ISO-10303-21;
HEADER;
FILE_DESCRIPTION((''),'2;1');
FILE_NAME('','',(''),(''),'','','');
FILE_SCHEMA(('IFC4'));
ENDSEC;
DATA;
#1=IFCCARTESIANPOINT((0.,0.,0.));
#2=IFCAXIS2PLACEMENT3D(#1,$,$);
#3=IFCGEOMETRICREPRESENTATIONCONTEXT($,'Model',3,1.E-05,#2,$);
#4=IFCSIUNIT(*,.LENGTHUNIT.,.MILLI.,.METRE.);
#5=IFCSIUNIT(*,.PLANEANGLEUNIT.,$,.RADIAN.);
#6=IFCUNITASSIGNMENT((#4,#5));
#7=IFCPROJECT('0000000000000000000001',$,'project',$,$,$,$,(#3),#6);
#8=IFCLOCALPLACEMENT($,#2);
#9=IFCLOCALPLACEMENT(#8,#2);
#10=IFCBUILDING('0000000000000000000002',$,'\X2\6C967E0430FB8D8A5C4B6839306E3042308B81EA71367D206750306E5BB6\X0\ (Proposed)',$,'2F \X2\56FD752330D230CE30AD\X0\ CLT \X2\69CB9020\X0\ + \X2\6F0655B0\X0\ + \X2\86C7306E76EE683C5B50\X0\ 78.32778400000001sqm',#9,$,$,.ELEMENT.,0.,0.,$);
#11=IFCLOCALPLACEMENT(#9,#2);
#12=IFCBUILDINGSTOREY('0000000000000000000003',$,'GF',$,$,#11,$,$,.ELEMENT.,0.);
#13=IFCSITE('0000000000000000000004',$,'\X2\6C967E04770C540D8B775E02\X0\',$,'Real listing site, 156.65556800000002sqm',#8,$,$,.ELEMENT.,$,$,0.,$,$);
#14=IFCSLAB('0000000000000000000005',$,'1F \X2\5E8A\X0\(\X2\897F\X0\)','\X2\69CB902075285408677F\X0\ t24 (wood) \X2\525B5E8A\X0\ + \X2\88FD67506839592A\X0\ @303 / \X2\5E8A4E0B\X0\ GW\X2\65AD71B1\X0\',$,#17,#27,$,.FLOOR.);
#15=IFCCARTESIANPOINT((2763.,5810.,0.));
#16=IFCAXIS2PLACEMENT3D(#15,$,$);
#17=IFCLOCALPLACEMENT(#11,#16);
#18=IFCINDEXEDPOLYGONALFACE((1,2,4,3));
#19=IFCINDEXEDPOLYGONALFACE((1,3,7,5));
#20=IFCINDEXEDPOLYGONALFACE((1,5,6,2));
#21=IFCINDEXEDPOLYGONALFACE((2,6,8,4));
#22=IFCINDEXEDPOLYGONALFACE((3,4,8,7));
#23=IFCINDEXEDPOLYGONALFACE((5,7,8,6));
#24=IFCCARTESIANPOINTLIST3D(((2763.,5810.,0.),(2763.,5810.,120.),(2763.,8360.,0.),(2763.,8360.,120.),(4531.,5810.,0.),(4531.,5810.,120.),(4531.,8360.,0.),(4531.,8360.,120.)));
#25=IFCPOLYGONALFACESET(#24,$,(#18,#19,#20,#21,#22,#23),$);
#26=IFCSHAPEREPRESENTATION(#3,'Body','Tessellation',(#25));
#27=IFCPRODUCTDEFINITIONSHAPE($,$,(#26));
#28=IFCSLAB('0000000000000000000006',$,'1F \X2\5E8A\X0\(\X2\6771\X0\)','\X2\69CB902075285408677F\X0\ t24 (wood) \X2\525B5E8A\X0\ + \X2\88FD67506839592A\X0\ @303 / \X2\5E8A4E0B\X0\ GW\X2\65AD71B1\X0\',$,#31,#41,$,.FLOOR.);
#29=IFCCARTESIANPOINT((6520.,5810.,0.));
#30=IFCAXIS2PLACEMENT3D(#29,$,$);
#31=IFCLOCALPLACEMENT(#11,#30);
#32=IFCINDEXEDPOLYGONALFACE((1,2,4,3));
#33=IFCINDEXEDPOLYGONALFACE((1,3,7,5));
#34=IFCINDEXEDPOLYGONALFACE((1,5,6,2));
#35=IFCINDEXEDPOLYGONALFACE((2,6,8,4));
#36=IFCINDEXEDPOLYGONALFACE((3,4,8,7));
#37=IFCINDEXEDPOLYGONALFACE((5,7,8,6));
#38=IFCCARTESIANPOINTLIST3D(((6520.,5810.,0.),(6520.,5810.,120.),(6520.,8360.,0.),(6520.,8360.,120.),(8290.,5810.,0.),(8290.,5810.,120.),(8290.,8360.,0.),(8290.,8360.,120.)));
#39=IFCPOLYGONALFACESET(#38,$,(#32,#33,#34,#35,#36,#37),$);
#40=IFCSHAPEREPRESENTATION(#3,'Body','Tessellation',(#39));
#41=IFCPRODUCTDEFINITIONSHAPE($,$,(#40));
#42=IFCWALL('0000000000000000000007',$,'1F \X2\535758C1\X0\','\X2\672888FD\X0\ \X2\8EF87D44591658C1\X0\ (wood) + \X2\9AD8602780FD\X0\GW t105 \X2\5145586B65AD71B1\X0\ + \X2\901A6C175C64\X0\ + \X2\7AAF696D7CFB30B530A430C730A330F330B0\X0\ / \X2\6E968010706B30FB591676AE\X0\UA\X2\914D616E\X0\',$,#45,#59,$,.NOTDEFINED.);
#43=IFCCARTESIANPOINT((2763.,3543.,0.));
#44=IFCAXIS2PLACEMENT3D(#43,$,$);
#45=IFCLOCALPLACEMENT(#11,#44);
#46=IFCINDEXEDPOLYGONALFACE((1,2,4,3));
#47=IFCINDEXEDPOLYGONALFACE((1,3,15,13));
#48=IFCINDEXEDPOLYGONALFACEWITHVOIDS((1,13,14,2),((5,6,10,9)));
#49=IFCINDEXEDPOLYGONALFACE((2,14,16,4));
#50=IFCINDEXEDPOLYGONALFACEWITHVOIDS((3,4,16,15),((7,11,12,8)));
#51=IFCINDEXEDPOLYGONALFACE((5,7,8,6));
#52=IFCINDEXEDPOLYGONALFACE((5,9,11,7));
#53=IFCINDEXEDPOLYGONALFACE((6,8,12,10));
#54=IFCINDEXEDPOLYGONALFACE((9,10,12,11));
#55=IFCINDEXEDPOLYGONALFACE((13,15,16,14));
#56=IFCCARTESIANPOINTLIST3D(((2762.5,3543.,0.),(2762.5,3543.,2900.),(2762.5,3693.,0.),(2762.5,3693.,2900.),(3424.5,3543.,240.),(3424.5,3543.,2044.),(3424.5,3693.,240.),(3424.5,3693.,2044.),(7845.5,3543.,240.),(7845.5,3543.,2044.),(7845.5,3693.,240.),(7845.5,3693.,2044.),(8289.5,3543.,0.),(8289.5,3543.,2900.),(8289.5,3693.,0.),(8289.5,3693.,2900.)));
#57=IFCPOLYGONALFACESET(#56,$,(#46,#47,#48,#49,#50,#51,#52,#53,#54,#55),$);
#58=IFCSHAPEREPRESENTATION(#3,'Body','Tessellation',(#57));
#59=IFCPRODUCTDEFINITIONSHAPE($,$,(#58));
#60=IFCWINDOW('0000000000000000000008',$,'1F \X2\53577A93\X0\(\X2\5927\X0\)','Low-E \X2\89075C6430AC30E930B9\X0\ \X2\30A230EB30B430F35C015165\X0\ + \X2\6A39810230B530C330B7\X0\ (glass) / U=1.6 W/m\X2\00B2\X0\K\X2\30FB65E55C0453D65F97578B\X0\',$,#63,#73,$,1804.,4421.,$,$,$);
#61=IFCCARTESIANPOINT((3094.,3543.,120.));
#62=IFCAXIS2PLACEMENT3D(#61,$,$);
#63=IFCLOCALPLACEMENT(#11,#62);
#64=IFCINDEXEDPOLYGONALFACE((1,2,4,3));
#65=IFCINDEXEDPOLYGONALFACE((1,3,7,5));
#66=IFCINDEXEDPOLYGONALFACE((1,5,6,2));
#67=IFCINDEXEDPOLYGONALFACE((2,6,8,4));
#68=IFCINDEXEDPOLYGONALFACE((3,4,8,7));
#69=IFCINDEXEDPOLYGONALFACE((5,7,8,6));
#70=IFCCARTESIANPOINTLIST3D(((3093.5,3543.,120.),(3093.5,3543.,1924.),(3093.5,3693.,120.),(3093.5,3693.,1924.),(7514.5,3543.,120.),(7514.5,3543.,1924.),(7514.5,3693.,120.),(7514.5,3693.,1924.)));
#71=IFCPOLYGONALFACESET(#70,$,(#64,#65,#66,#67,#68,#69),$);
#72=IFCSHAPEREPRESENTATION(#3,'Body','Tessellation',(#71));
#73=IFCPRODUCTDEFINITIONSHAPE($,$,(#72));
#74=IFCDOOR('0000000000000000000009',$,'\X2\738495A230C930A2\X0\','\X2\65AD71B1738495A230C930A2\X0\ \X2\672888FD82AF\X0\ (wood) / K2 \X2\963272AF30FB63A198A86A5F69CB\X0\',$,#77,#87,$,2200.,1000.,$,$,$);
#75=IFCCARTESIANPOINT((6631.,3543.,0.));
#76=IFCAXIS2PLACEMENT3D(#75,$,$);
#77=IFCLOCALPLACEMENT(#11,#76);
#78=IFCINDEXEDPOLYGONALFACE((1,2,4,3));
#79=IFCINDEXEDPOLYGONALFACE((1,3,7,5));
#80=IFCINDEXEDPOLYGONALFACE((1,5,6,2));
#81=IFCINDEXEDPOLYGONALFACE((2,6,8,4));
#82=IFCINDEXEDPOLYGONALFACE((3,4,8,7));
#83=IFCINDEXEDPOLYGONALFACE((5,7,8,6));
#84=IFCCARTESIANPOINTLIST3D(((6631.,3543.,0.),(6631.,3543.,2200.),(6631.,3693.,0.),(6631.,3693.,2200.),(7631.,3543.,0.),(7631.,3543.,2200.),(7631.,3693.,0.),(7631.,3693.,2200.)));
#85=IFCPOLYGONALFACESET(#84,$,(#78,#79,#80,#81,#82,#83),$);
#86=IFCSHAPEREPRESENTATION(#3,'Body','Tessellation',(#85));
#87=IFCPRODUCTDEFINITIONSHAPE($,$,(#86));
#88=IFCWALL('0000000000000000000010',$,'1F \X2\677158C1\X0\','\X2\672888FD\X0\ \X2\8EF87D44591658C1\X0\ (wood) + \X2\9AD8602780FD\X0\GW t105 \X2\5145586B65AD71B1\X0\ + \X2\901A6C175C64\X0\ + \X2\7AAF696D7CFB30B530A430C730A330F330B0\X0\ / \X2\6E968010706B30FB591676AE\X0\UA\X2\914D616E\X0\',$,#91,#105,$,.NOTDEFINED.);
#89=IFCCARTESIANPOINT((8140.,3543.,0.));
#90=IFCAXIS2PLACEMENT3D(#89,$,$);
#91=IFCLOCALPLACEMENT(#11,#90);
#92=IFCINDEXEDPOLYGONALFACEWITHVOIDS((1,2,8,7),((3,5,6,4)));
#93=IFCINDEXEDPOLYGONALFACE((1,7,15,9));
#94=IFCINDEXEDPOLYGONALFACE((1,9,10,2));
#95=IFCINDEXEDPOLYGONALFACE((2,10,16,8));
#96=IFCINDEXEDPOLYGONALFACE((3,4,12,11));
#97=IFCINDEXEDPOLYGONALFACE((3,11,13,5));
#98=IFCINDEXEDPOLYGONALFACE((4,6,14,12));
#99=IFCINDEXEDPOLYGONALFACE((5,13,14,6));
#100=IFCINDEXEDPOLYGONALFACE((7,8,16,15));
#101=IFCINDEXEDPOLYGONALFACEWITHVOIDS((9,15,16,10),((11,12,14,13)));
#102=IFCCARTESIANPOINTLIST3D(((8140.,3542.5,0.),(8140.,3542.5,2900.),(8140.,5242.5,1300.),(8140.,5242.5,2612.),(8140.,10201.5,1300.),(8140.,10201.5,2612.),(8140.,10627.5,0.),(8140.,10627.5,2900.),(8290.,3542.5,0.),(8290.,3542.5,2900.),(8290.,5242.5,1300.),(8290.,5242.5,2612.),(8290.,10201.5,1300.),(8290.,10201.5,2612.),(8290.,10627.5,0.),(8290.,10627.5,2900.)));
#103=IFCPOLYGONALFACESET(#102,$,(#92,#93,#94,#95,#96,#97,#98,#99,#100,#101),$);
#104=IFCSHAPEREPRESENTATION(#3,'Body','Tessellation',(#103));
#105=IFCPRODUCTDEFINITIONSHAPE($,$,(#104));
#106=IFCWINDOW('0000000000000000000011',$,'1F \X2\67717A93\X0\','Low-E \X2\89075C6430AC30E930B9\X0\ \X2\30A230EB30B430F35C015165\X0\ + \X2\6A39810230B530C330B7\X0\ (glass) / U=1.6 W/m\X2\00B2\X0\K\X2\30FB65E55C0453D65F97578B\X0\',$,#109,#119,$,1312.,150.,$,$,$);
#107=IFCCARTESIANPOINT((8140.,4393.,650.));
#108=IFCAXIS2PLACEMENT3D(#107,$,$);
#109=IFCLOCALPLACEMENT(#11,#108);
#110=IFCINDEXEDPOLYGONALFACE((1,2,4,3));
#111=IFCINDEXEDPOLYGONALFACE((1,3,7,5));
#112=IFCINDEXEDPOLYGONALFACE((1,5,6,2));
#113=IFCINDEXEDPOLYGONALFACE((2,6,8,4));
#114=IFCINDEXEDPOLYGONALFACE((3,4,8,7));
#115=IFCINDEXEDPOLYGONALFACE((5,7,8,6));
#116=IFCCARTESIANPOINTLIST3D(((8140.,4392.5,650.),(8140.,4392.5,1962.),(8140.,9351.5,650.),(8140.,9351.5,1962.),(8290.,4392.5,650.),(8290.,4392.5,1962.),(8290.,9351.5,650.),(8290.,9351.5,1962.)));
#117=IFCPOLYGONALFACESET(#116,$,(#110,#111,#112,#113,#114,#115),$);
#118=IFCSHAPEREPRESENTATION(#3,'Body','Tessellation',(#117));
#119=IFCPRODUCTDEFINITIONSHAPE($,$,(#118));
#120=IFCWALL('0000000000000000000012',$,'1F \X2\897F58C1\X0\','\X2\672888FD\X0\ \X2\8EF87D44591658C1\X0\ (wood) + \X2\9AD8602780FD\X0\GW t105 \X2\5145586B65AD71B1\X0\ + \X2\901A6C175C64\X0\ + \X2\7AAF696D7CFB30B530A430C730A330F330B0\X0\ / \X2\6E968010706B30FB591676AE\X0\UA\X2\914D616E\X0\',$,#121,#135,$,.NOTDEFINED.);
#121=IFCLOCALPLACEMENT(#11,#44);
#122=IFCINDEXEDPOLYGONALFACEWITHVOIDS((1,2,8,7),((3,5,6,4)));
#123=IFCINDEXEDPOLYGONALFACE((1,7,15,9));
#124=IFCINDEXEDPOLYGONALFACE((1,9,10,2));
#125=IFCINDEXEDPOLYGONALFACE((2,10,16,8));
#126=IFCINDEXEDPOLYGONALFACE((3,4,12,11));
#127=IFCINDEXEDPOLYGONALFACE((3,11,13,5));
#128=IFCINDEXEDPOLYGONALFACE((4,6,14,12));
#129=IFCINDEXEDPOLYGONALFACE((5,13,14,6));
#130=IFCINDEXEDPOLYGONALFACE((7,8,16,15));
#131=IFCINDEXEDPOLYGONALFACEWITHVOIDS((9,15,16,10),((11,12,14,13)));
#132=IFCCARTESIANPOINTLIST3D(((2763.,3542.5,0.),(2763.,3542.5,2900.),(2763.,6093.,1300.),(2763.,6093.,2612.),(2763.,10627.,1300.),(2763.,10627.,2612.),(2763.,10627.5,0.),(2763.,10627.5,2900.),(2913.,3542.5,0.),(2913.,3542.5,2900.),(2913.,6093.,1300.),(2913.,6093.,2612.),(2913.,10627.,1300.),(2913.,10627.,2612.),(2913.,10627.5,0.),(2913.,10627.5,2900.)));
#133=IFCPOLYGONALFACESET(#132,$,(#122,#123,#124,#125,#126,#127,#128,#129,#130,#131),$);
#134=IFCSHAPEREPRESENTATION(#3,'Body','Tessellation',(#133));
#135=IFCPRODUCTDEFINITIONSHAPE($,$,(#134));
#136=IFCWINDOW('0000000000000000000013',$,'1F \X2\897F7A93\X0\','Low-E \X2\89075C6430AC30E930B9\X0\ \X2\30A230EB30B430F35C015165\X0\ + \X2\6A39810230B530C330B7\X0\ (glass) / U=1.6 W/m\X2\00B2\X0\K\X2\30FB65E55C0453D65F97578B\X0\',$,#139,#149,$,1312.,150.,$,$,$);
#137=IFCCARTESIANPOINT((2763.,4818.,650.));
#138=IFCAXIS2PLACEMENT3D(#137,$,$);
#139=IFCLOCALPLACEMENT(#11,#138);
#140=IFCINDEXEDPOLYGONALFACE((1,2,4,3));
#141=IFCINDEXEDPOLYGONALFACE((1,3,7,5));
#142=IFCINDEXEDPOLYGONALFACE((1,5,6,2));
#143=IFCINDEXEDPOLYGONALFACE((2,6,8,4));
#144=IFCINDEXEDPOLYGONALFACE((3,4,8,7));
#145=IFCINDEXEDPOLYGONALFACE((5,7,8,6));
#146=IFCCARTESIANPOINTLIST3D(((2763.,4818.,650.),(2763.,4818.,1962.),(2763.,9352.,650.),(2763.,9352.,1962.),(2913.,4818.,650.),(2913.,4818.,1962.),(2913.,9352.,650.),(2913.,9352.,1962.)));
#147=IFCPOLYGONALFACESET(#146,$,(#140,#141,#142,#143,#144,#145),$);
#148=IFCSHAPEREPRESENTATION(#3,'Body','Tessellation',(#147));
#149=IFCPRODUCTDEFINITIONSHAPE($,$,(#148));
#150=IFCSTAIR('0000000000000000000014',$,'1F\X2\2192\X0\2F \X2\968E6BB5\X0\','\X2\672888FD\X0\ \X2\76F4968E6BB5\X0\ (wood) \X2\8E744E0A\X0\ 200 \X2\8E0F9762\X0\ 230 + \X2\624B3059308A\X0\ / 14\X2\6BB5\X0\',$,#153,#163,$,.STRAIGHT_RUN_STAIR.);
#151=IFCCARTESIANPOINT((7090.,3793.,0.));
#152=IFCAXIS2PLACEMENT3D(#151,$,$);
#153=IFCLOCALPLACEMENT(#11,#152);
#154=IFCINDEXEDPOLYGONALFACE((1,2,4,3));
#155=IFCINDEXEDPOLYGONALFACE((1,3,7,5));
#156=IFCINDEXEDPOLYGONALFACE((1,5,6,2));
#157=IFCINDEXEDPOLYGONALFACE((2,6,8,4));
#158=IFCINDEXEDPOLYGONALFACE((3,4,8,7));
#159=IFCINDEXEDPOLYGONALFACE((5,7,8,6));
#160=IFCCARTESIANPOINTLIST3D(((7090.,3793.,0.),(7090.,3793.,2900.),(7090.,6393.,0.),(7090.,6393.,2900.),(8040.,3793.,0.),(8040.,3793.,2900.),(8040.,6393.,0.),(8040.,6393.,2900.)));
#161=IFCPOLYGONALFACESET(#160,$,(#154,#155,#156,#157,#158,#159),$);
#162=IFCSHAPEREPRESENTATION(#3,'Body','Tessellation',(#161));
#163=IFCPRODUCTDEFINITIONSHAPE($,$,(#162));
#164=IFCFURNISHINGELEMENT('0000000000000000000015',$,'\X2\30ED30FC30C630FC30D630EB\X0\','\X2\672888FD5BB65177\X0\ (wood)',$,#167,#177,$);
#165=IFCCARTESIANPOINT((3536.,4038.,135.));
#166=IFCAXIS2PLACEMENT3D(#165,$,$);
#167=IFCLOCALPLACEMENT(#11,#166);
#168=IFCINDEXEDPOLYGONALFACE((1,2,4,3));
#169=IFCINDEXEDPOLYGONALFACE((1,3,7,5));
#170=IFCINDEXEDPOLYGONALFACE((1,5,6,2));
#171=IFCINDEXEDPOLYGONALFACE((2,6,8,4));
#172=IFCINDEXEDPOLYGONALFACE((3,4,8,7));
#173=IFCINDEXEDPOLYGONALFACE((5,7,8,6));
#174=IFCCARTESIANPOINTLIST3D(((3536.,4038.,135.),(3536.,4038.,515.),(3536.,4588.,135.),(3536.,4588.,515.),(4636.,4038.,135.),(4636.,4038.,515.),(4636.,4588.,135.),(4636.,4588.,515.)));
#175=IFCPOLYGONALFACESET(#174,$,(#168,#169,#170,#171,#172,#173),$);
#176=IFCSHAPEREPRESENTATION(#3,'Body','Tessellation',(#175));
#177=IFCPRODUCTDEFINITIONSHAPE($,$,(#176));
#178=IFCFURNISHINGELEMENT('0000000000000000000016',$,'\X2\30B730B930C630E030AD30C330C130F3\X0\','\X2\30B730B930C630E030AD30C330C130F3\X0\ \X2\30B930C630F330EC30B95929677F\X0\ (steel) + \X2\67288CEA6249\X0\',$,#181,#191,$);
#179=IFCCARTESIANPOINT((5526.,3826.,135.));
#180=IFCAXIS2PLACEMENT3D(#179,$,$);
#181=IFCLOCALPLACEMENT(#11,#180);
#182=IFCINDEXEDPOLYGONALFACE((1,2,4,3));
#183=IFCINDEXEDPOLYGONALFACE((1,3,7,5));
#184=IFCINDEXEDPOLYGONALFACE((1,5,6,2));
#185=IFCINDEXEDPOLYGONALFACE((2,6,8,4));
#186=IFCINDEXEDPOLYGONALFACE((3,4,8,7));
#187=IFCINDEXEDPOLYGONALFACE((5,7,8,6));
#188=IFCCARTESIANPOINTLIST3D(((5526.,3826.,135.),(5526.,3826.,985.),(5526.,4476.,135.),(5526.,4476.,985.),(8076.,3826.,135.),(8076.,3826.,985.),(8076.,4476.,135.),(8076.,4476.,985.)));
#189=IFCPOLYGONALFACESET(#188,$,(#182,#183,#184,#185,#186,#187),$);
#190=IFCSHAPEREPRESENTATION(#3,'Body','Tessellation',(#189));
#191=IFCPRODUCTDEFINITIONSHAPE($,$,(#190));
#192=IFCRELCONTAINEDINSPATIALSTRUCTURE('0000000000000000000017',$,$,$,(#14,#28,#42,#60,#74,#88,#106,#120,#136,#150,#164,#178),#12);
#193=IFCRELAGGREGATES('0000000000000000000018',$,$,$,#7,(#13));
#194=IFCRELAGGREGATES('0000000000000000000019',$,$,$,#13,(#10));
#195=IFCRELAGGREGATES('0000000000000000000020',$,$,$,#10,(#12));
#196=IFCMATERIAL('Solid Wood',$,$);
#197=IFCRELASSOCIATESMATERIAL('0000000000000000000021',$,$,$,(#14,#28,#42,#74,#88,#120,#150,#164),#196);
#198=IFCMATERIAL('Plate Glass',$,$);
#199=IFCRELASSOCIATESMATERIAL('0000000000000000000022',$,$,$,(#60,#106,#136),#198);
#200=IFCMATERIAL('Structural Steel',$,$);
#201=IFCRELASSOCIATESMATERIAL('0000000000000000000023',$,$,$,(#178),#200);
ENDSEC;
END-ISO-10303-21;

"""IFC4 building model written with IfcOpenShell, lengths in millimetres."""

from ifc_helpers import new_model, si_unit, frame, frame_2d, origin, place, context, project, spatial, rectangle, extrude, material, element, fill, save


model = new_model("IFC4")

# Units and contexts
model_context = context("Model", 3, precision=1e-05, world=origin())
ifc_project = project(units=[si_unit("LENGTHUNIT", "METRE", prefix="MILLI"), si_unit("PLANEANGLEUNIT", "RADIAN")], contexts=[model_context])

# Site, building, storey
site_placement = place(None, origin())
site = spatial("IfcSite", under=ifc_project, at=site_placement, Name="沖縄県名護市", ObjectType="Real listing site, 156.65556800000002sqm", CompositionType="ELEMENT", RefElevation=0.0)
building_placement = place(site_placement, origin())
building = spatial("IfcBuilding", under=site, at=building_placement, Name="沖縄・越屋根のある自然素材の家 (Proposed)", ObjectType="2F 国産ヒノキ CLT 構造 + 漆喰 + 蛇の目格子 78.32778400000001sqm", CompositionType="ELEMENT", ElevationOfRefHeight=0.0, ElevationOfTerrain=0.0)
storey_placement = place(building_placement, origin())
storey = spatial("IfcBuildingStorey", under=building, at=storey_placement, Name="GF", CompositionType="ELEMENT", Elevation=0.0)

# Slabs
ifc_material_1 = material(Name="Solid Wood")
slab_1_placement = place(storey_placement, frame((2763.0, 5810.0, 0.0)))
element("IfcSlab", 1, at=slab_1_placement, inside=storey, material=ifc_material_1, Name="1F 床(西)", Description="構造用合板 t24 (wood) 剛床 + 製材根太 @303 / 床下 GW断熱", PredefinedType="FLOOR", context=model_context, shape_type="SweptSolid", body=[
    extrude(rectangle(XDim=1768.0, YDim=2550.0, at=frame_2d((884.0, 1275.0))), frame((2763.0, 5810.0, 0.0)), (0.0, 0.0, 1.0), 120.0),
])
slab_2_placement = place(storey_placement, frame((6520.0, 5810.0, 0.0)))
element("IfcSlab", 2, at=slab_2_placement, inside=storey, material=ifc_material_1, Name="1F 床(東)", Description="構造用合板 t24 (wood) 剛床 + 製材根太 @303 / 床下 GW断熱", PredefinedType="FLOOR", context=model_context, shape_type="SweptSolid", body=[
    extrude(rectangle(XDim=1770.0, YDim=2550.0, at=frame_2d((885.0, 1275.0))), frame((6520.0, 5810.0, 0.0)), (0.0, 0.0, 1.0), 120.0),
])

# Wall, openings, window, door
wall_1_placement = place(storey_placement, frame((2763.0, 3543.0, 0.0)))
wall_1 = element("IfcWall", 3, at=wall_1_placement, inside=storey, material=ifc_material_1, Name="1F 南壁", Description="木製 軸組外壁 (wood) + 高性能GW t105 充填断熱 + 通気層 + 窯業系サイディング / 準耐火・外皮UA配慮", PredefinedType="NOTDEFINED", context=model_context, shape_type="SweptSolid", body=[
    extrude(rectangle(XDim=5527.0, YDim=150.0, at=frame_2d((2763.0, 75.0))), frame((2763.0, 3543.0, 0.0)), (0.0, 0.0, 1.0), 2900.0),
])
opening_1_placement = place(storey_placement, frame((3094.0, 3543.0, 120.0)))
opening_1 = element("IfcOpeningElement", 4, at=opening_1_placement, cuts=wall_1, PredefinedType="NOTDEFINED", context=model_context, shape_type="SweptSolid", body=[
    extrude(rectangle(XDim=4421.0, YDim=150.0, at=frame_2d((2210.0, 75.0))), frame((3094.0, 3543.0, 120.0)), (0.0, 0.0, 1.0), 1804.0),
])
opening_2_placement = place(storey_placement, frame((6631.0, 3543.0, 0.0)))
opening_2 = element("IfcOpeningElement", 5, at=opening_2_placement, cuts=wall_1, PredefinedType="NOTDEFINED", context=model_context, shape_type="SweptSolid", body=[
    extrude(rectangle(XDim=1000.0, YDim=150.0, at=frame_2d((500.0, 75.0))), frame((6631.0, 3543.0, 0.0)), (0.0, 0.0, 1.0), 2200.0),
])
ifc_material_2 = material(Name="Plate Glass")
window_1_placement = place(storey_placement, frame((3094.0, 3543.0, 120.0)))
window_1 = element("IfcWindow", 6, at=window_1_placement, inside=storey, material=ifc_material_2, Name="1F 南窓(大)", Description="Low-E 複層ガラス アルゴン封入 + 樹脂サッシ (glass) / U=1.6 W/m²K・日射取得型", OverallHeight=1804.0, OverallWidth=4421.0, context=model_context, shape_type="SweptSolid", body=[
    extrude(rectangle(XDim=4421.0, YDim=150.0, at=frame_2d((2210.0, 75.0))), frame((3094.0, 3543.0, 120.0)), (0.0, 0.0, 1.0), 1804.0),
])
fill(opening_1, window_1)
door_placement = place(storey_placement, frame((6631.0, 3543.0, 0.0)))
door = element("IfcDoor", 7, at=door_placement, inside=storey, material=ifc_material_1, Name="玄関ドア", Description="断熱玄関ドア 木製芯 (wood) / K2 防犯・採風機構", OverallHeight=2200.0, OverallWidth=1000.0, context=model_context, shape_type="SweptSolid", body=[
    extrude(rectangle(XDim=1000.0, YDim=150.0, at=frame_2d((500.0, 75.0))), frame((6631.0, 3543.0, 0.0)), (0.0, 0.0, 1.0), 2200.0),
])
fill(opening_2, door)

# Walls, openings, windows
wall_2_placement = place(storey_placement, frame((8140.0, 3543.0, 0.0)))
wall_2 = element("IfcWall", 8, at=wall_2_placement, inside=storey, material=ifc_material_1, Name="1F 東壁", Description="木製 軸組外壁 (wood) + 高性能GW t105 充填断熱 + 通気層 + 窯業系サイディング / 準耐火・外皮UA配慮", PredefinedType="NOTDEFINED", context=model_context, shape_type="SweptSolid", body=[
    extrude(rectangle(XDim=150.0, YDim=7085.0, at=frame_2d((75.0, 3542.0))), frame((8140.0, 3543.0, 0.0)), (0.0, 0.0, 1.0), 2900.0),
])
opening_3_placement = place(storey_placement, frame((8140.0, 4393.0, 650.0)))
opening_3 = element("IfcOpeningElement", 9, at=opening_3_placement, cuts=wall_2, PredefinedType="NOTDEFINED", context=model_context, shape_type="SweptSolid", body=[
    extrude(rectangle(XDim=150.0, YDim=4959.0, at=frame_2d((75.0, 2479.0))), frame((8140.0, 4393.0, 650.0)), (0.0, 0.0, 1.0), 1312.0),
])
window_2_placement = place(storey_placement, frame((8140.0, 4393.0, 650.0)))
window_2 = element("IfcWindow", 10, at=window_2_placement, inside=storey, material=ifc_material_2, Name="1F 東窓", Description="Low-E 複層ガラス アルゴン封入 + 樹脂サッシ (glass) / U=1.6 W/m²K・日射取得型", OverallHeight=1312.0, OverallWidth=150.0, context=model_context, shape_type="SweptSolid", body=[
    extrude(rectangle(XDim=150.0, YDim=4959.0, at=frame_2d((75.0, 2479.0))), frame((8140.0, 4393.0, 650.0)), (0.0, 0.0, 1.0), 1312.0),
])
fill(opening_3, window_2)
wall_3_placement = place(storey_placement, frame((2763.0, 3543.0, 0.0)))
wall_3 = element("IfcWall", 11, at=wall_3_placement, inside=storey, material=ifc_material_1, Name="1F 西壁", Description="木製 軸組外壁 (wood) + 高性能GW t105 充填断熱 + 通気層 + 窯業系サイディング / 準耐火・外皮UA配慮", PredefinedType="NOTDEFINED", context=model_context, shape_type="SweptSolid", body=[
    extrude(rectangle(XDim=150.0, YDim=7085.0, at=frame_2d((75.0, 3542.0))), frame((2763.0, 3543.0, 0.0)), (0.0, 0.0, 1.0), 2900.0),
])
opening_4_placement = place(storey_placement, frame((2763.0, 4818.0, 650.0)))
opening_4 = element("IfcOpeningElement", 12, at=opening_4_placement, cuts=wall_3, PredefinedType="NOTDEFINED", context=model_context, shape_type="SweptSolid", body=[
    extrude(rectangle(XDim=150.0, YDim=4534.0, at=frame_2d((75.0, 2267.0))), frame((2763.0, 4818.0, 650.0)), (0.0, 0.0, 1.0), 1312.0),
])
window_3_placement = place(storey_placement, frame((2763.0, 4818.0, 650.0)))
window_3 = element("IfcWindow", 13, at=window_3_placement, inside=storey, material=ifc_material_2, Name="1F 西窓", Description="Low-E 複層ガラス アルゴン封入 + 樹脂サッシ (glass) / U=1.6 W/m²K・日射取得型", OverallHeight=1312.0, OverallWidth=150.0, context=model_context, shape_type="SweptSolid", body=[
    extrude(rectangle(XDim=150.0, YDim=4534.0, at=frame_2d((75.0, 2267.0))), frame((2763.0, 4818.0, 650.0)), (0.0, 0.0, 1.0), 1312.0),
])
fill(opening_4, window_3)

# Stair
stair_placement = place(storey_placement, frame((7090.0, 3793.0, 0.0)))
element("IfcStair", 14, at=stair_placement, inside=storey, material=ifc_material_1, Name="1F→2F 階段", Description="木製 直階段 (wood) 蹴上 200 踏面 230 + 手すり / 14段", PredefinedType="STRAIGHT_RUN_STAIR", context=model_context, shape_type="SweptSolid", body=[
    extrude(rectangle(XDim=950.0, YDim=2600.0, at=frame_2d((475.0, 1300.0))), frame((7090.0, 3793.0, 0.0)), (0.0, 0.0, 1.0), 2900.0),
])

# Furnishing elements
furnishing_1_placement = place(storey_placement, frame((3536.0, 4038.0, 135.0)))
element("IfcFurnishingElement", 15, at=furnishing_1_placement, inside=storey, material=ifc_material_1, Name="ローテーブル", Description="木製家具 (wood)", context=model_context, shape_type="SweptSolid", body=[
    extrude(rectangle(XDim=1100.0, YDim=550.0, at=frame_2d((550.0, 275.0))), frame((3536.0, 4038.0, 135.0)), (0.0, 0.0, 1.0), 380.0),
])
ifc_material_3 = material(Name="Structural Steel")
furnishing_2_placement = place(storey_placement, frame((5526.0, 3826.0, 135.0)))
element("IfcFurnishingElement", 16, at=furnishing_2_placement, inside=storey, material=ifc_material_3, Name="システムキッチン", Description="システムキッチン ステンレス天板 (steel) + 木質扉", context=model_context, shape_type="SweptSolid", body=[
    extrude(rectangle(XDim=2550.0, YDim=650.0, at=frame_2d((1275.0, 325.0))), frame((5526.0, 3826.0, 135.0)), (0.0, 0.0, 1.0), 850.0),
])

save(model, "model.ifc")
